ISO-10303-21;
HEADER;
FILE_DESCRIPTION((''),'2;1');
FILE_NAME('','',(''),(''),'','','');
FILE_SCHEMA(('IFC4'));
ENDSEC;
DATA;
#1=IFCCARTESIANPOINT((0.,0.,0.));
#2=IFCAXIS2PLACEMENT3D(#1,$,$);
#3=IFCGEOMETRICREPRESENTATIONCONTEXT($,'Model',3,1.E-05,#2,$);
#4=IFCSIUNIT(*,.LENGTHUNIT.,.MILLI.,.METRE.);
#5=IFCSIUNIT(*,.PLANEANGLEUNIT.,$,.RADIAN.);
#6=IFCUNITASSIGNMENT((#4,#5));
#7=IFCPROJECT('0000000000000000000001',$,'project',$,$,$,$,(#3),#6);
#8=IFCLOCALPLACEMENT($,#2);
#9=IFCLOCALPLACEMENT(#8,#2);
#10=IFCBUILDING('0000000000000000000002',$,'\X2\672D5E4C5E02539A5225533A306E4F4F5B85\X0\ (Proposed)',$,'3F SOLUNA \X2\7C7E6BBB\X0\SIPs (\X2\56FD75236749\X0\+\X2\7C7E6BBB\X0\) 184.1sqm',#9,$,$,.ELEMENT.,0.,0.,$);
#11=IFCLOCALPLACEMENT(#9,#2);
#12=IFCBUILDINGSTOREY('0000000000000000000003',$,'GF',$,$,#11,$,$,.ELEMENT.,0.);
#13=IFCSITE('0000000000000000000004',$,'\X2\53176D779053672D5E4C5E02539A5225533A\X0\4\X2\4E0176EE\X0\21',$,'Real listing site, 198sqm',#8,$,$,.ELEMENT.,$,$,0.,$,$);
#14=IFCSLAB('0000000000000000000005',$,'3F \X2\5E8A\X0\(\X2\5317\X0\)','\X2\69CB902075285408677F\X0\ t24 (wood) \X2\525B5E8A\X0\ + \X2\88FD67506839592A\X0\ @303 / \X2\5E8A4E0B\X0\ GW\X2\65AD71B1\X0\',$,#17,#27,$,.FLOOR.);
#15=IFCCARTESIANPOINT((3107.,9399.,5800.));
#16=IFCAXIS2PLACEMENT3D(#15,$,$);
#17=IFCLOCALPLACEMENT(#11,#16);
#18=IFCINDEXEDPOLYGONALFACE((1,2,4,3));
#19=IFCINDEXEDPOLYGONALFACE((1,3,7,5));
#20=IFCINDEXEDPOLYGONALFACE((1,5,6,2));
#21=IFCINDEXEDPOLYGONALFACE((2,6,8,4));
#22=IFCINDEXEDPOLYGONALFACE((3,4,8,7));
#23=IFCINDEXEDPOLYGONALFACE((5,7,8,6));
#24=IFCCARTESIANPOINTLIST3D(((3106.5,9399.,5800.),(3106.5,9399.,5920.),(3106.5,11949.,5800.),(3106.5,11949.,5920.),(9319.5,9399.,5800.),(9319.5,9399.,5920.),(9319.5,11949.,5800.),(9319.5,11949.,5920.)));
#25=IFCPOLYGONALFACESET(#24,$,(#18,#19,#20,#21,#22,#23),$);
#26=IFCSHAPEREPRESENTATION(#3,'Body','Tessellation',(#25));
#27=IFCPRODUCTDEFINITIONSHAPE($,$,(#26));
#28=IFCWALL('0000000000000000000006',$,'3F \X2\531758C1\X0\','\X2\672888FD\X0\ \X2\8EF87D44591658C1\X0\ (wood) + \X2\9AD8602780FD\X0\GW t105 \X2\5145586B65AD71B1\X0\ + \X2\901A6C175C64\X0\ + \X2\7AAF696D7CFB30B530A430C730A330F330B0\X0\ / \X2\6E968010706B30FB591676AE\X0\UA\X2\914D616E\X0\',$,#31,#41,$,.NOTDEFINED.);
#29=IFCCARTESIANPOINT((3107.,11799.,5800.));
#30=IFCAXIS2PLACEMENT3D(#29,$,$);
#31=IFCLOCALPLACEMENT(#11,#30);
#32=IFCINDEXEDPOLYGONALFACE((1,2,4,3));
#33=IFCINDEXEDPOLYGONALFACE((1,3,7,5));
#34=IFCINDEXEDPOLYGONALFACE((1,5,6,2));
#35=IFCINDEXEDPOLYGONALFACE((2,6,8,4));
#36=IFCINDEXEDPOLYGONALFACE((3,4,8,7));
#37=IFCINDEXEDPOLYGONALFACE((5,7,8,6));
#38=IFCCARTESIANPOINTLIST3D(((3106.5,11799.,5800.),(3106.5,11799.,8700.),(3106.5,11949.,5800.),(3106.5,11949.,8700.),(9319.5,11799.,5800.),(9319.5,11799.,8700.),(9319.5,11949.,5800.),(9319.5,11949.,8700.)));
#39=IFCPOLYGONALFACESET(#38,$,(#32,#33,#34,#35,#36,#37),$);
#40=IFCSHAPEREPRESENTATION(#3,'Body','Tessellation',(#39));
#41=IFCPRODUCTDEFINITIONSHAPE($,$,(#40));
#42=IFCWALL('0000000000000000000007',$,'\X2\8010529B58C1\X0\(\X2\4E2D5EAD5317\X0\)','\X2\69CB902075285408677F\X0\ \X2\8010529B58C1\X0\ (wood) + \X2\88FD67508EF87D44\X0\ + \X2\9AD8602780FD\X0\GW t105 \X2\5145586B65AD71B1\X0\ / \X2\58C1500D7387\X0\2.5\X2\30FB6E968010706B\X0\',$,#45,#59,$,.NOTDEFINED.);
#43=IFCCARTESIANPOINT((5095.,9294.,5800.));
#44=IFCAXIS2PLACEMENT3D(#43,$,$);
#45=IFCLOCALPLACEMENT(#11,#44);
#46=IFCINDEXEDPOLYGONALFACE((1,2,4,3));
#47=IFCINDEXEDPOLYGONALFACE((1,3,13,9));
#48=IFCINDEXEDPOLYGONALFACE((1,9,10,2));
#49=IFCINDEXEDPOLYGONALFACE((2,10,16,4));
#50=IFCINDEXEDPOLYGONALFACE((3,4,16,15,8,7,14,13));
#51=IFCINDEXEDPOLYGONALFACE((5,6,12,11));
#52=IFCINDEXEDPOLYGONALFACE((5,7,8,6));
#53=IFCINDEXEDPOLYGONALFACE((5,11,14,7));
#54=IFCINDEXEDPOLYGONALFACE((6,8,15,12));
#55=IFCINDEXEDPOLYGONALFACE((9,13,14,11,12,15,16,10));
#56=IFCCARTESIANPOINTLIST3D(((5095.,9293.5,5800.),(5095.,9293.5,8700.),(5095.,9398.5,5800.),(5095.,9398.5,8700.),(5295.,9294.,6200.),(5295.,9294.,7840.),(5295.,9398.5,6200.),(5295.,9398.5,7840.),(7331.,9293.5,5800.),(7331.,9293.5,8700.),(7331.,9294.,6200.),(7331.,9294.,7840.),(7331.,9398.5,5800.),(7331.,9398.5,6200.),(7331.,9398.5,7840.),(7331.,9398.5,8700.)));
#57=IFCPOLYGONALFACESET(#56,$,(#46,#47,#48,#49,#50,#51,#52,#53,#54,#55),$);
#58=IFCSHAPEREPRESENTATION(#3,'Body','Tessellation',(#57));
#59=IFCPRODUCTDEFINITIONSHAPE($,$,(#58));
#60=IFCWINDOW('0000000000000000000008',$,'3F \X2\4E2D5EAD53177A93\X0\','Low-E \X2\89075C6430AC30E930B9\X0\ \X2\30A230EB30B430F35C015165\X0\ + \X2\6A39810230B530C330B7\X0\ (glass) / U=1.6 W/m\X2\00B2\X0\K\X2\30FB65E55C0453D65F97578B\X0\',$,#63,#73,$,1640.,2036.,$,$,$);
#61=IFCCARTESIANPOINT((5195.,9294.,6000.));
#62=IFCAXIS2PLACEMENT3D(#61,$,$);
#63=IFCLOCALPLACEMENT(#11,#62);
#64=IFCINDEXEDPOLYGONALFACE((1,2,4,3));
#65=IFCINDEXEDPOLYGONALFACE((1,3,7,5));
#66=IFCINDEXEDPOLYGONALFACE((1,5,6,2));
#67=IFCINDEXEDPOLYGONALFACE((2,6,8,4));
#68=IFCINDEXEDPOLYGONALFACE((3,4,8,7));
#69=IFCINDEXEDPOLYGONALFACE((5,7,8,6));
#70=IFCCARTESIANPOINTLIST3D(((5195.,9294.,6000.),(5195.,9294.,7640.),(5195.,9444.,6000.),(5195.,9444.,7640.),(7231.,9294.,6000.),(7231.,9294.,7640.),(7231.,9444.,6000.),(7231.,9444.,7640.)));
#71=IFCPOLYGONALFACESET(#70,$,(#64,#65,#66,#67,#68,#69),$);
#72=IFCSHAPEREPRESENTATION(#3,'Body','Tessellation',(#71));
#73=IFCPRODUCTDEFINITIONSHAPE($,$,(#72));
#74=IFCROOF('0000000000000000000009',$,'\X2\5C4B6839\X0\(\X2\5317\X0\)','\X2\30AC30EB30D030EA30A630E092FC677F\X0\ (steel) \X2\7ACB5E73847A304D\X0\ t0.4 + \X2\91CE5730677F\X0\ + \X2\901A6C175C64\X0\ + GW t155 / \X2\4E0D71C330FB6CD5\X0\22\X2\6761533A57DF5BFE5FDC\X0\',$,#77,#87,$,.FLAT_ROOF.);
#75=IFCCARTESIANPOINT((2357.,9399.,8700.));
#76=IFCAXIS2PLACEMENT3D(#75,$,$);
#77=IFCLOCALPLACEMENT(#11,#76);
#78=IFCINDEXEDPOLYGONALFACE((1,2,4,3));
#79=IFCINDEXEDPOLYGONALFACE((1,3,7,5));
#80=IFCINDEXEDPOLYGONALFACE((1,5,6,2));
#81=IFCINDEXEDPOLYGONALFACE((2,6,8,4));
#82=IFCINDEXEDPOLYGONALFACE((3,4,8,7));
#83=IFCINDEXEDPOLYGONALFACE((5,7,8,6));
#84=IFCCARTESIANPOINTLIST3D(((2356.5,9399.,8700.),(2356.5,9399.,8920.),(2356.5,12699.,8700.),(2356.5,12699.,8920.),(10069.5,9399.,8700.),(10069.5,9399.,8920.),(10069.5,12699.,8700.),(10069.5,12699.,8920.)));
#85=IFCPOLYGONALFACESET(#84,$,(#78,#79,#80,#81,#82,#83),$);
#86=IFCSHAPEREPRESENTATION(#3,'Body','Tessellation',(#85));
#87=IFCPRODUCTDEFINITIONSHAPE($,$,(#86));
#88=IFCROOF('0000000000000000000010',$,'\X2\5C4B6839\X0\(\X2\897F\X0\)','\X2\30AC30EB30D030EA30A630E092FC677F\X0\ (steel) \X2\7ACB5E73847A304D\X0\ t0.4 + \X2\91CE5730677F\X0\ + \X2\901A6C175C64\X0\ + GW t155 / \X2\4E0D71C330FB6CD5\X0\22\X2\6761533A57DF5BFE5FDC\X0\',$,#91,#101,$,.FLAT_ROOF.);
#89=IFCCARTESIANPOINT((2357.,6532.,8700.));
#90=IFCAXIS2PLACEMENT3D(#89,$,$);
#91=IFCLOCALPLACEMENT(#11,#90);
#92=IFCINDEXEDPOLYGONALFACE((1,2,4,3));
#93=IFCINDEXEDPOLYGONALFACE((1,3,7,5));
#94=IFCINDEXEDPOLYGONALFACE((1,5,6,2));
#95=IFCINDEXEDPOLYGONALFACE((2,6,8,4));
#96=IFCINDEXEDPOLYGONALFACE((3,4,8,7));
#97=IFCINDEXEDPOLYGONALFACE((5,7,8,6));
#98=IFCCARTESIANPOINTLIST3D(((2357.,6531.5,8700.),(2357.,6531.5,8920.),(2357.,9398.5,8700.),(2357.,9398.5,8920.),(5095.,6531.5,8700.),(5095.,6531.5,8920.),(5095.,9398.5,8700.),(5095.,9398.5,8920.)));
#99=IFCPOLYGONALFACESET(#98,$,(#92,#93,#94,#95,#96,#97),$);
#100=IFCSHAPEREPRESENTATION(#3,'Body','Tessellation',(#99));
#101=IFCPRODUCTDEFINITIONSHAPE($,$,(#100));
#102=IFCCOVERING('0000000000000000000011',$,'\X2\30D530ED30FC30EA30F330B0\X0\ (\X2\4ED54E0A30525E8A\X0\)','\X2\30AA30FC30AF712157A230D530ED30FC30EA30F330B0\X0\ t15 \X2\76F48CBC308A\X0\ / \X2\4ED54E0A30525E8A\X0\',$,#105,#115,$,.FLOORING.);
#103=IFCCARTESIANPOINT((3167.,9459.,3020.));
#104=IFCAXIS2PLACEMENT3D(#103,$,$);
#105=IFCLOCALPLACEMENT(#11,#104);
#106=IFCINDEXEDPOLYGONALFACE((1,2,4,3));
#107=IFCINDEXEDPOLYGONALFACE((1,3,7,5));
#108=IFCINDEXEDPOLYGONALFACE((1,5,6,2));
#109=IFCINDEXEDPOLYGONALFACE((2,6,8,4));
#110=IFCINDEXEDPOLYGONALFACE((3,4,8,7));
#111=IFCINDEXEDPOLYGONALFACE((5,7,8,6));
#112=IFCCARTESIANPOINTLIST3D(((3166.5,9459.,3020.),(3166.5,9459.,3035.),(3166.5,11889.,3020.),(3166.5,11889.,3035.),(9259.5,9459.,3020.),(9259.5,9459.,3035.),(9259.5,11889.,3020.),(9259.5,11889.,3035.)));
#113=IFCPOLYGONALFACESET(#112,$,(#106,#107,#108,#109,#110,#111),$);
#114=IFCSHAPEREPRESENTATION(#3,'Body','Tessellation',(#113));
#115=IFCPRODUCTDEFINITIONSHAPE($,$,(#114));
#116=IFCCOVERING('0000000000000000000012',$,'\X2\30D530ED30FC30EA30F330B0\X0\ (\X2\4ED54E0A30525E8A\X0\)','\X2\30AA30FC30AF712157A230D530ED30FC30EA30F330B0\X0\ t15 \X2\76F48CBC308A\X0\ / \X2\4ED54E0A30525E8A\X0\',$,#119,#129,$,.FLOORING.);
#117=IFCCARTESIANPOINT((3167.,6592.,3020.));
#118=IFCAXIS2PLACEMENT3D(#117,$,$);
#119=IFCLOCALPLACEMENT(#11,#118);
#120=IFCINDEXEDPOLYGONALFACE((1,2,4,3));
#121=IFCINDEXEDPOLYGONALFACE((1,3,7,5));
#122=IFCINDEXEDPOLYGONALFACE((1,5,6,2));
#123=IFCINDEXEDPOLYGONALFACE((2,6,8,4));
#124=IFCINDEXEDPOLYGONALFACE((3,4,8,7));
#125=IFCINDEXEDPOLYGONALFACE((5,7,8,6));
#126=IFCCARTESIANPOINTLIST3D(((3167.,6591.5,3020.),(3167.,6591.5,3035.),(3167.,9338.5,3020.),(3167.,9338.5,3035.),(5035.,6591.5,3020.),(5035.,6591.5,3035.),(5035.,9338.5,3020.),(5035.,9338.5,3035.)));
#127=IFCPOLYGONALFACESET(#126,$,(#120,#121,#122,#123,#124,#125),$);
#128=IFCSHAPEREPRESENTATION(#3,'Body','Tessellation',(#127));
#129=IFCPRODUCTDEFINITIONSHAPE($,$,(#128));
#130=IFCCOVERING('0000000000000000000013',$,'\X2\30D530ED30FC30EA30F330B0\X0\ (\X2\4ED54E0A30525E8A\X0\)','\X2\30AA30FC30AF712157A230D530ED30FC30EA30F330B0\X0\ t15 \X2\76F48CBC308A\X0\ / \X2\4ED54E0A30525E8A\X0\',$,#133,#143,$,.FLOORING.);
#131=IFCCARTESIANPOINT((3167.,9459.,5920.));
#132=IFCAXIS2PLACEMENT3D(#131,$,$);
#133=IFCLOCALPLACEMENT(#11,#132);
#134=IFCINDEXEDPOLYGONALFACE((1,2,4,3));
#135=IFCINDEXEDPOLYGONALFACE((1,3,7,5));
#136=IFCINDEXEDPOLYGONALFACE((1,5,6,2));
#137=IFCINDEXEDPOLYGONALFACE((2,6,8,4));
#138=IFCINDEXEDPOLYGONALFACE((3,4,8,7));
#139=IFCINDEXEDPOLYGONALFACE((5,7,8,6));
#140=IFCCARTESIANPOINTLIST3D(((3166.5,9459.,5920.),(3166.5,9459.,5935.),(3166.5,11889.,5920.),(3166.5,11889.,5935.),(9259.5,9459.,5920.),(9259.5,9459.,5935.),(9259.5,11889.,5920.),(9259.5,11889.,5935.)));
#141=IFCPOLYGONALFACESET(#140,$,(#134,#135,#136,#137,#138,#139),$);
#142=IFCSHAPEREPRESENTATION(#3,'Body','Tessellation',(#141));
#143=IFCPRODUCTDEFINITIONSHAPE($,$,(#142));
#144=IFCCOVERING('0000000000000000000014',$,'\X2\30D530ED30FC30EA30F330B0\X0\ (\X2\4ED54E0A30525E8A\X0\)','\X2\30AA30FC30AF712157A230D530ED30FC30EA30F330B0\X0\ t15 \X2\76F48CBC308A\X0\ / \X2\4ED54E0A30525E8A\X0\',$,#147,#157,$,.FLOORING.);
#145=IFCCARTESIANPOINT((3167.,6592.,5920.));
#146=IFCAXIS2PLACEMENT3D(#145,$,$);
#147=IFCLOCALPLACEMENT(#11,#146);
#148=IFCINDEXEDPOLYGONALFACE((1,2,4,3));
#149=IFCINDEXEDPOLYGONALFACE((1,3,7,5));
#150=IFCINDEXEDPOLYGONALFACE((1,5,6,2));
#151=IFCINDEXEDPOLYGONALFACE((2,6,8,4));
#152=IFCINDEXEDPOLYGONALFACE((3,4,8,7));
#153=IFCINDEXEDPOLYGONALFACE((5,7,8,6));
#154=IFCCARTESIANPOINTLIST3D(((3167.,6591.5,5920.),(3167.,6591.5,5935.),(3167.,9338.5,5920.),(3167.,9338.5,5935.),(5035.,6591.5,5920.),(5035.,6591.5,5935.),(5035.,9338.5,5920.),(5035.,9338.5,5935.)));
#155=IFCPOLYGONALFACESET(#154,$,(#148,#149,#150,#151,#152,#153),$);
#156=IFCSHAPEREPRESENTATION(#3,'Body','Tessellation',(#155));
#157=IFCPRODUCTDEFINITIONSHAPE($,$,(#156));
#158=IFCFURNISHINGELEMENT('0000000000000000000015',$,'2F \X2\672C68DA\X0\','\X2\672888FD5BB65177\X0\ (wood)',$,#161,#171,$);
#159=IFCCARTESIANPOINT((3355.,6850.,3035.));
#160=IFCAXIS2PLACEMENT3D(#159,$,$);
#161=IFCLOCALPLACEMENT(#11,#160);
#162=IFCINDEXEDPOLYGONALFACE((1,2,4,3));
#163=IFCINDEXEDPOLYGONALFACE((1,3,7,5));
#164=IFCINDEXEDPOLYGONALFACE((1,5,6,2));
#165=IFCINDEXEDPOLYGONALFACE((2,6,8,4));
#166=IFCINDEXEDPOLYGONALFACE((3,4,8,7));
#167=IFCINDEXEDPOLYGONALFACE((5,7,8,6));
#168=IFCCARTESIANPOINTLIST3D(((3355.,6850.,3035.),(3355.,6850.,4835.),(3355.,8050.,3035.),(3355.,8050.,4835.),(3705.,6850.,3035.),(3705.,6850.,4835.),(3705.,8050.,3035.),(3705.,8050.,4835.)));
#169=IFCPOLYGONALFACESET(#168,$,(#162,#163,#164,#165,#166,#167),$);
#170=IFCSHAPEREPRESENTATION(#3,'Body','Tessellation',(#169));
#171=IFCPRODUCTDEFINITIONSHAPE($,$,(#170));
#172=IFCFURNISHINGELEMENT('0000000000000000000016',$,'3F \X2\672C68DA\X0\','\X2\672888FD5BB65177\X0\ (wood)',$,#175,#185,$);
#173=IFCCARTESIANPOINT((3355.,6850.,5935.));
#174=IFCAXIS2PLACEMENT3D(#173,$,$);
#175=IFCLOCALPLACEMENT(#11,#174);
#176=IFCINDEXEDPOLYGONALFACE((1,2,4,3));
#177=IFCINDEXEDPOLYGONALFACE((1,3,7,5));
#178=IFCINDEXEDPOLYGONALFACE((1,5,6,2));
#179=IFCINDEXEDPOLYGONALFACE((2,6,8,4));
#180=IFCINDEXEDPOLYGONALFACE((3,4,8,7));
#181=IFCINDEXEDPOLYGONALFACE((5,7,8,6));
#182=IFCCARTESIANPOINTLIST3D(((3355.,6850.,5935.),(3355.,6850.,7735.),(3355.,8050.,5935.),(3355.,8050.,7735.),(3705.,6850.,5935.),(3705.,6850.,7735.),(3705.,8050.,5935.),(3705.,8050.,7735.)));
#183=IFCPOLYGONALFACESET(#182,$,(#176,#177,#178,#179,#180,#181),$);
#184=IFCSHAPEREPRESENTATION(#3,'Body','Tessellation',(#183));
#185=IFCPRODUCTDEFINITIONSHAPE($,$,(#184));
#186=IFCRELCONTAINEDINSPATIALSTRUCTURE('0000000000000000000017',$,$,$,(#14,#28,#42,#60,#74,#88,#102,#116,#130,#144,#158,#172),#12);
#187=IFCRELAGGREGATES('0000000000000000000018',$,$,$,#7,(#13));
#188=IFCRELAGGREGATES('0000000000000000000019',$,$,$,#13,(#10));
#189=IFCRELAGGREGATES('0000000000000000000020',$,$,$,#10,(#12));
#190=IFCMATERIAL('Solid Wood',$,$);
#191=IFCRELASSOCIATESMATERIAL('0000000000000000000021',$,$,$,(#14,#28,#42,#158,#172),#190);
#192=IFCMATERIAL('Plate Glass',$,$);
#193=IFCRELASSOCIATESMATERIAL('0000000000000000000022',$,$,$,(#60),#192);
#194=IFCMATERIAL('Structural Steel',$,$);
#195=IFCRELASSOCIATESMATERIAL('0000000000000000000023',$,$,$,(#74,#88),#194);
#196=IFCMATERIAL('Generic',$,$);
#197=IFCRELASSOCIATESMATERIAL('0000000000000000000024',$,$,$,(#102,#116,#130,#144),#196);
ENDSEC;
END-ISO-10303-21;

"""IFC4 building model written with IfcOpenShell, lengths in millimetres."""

from ifc_helpers import new_model, si_unit, frame, frame_2d, origin, place, context, project, spatial, rectangle, extrude, material, element, fill, save


model = new_model("IFC4")

# Units and contexts
model_context = context("Model", 3, precision=1e-05, world=origin())
ifc_project = project(units=[si_unit("LENGTHUNIT", "METRE", prefix="MILLI"), si_unit("PLANEANGLEUNIT", "RADIAN")], contexts=[model_context])

# Site, building, storey
site_placement = place(None, origin())
site = spatial("IfcSite", under=ifc_project, at=site_placement, Name="北海道札幌市厚別区4丁目21", ObjectType="Real listing site, 198sqm", CompositionType="ELEMENT", RefElevation=0.0)
building_placement = place(site_placement, origin())
building = spatial("IfcBuilding", under=site, at=building_placement, Name="札幌市厚別区の住宅 (Proposed)", ObjectType="3F SOLUNA 籾殻SIPs (国産杉+籾殻) 184.1sqm", CompositionType="ELEMENT", ElevationOfRefHeight=0.0, ElevationOfTerrain=0.0)
storey_placement = place(building_placement, origin())
storey = spatial("IfcBuildingStorey", under=building, at=storey_placement, Name="GF", CompositionType="ELEMENT", Elevation=0.0)

# Slab
ifc_material_1 = material(Name="Solid Wood")
slab_placement = place(storey_placement, frame((3107.0, 9399.0, 5800.0)))
element("IfcSlab", 1, at=slab_placement, inside=storey, material=ifc_material_1, Name="3F 床(北)", Description="構造用合板 t24 (wood) 剛床 + 製材根太 @303 / 床下 GW断熱", PredefinedType="FLOOR", context=model_context, shape_type="SweptSolid", body=[
    extrude(rectangle(XDim=6213.0, YDim=2550.0, at=frame_2d((3106.0, 1275.0))), frame((3107.0, 9399.0, 5800.0)), (0.0, 0.0, 1.0), 120.0),
])

# Wall
wall_1_placement = place(storey_placement, frame((3107.0, 11799.0, 5800.0)))
element("IfcWall", 2, at=wall_1_placement, inside=storey, material=ifc_material_1, Name="3F 北壁", Description="木製 軸組外壁 (wood) + 高性能GW t105 充填断熱 + 通気層 + 窯業系サイディング / 準耐火・外皮UA配慮", PredefinedType="NOTDEFINED", context=model_context, shape_type="SweptSolid", body=[
    extrude(rectangle(XDim=6213.0, YDim=150.0, at=frame_2d((3106.0, 75.0))), frame((3107.0, 11799.0, 5800.0)), (0.0, 0.0, 1.0), 2900.0),
])

# Wall, opening, window
wall_2_placement = place(storey_placement, frame((5095.0, 9294.0, 5800.0)))
wall_2 = element("IfcWall", 3, at=wall_2_placement, inside=storey, material=ifc_material_1, Name="耐力壁(中庭北)", Description="構造用合板 耐力壁 (wood) + 製材軸組 + 高性能GW t105 充填断熱 / 壁倍率2.5・準耐火", PredefinedType="NOTDEFINED", context=model_context, shape_type="SweptSolid", body=[
    extrude(rectangle(XDim=2236.0, YDim=105.0, at=frame_2d((1118.0, 52.0))), frame((5095.0, 9294.0, 5800.0)), (0.0, 0.0, 1.0), 2900.0),
])
opening_placement = place(storey_placement, frame((5195.0, 9294.0, 6000.0)))
opening = element("IfcOpeningElement", 4, at=opening_placement, cuts=wall_2, PredefinedType="NOTDEFINED", context=model_context, shape_type="SweptSolid", body=[
    extrude(rectangle(XDim=2036.0, YDim=150.0, at=frame_2d((1018.0, 75.0))), frame((5195.0, 9294.0, 6000.0)), (0.0, 0.0, 1.0), 1640.0),
])
ifc_material_2 = material(Name="Plate Glass")
window_1_placement = place(storey_placement, frame((5195.0, 9294.0, 6000.0)))
window_1 = element("IfcWindow", 5, at=window_1_placement, inside=storey, material=ifc_material_2, Name="3F 中庭北窓", Description="Low-E 複層ガラス アルゴン封入 + 樹脂サッシ (glass) / U=1.6 W/m²K・日射取得型", OverallHeight=1640.0, OverallWidth=2036.0, context=model_context, shape_type="SweptSolid", body=[
    extrude(rectangle(XDim=2036.0, YDim=150.0, at=frame_2d((1018.0, 75.0))), frame((5195.0, 9294.0, 6000.0)), (0.0, 0.0, 1.0), 1640.0),
])
fill(opening, window_1)

# Shared definitions
ifc_material_3 = material(Name="Generic")

# Roofs
ifc_material_4 = material(Name="Structural Steel")
roof_1_placement = place(storey_placement, frame((2357.0, 9399.0, 8700.0)))
element("IfcRoof", 6, at=roof_1_placement, inside=storey, material=ifc_material_4, Name="屋根(北)", Description="ガルバリウム鋼板 (steel) 立平葺き t0.4 + 野地板 + 通気層 + GW t155 / 不燃・法22条区域対応", PredefinedType="FLAT_ROOF", context=model_context, shape_type="SweptSolid", body=[
    extrude(rectangle(XDim=7713.0, YDim=3300.0, at=frame_2d((3856.0, 1650.0))), frame((2357.0, 9399.0, 8700.0)), (0.0, 0.0, 1.0), 220.0),
])
roof_2_placement = place(storey_placement, frame((2357.0, 6532.0, 8700.0)))
element("IfcRoof", 7, at=roof_2_placement, inside=storey, material=ifc_material_4, Name="屋根(西)", Description="ガルバリウム鋼板 (steel) 立平葺き t0.4 + 野地板 + 通気層 + GW t155 / 不燃・法22条区域対応", PredefinedType="FLAT_ROOF", context=model_context, shape_type="SweptSolid", body=[
    extrude(rectangle(XDim=2738.0, YDim=2867.0, at=frame_2d((1369.0, 1433.0))), frame((2357.0, 6532.0, 8700.0)), (0.0, 0.0, 1.0), 220.0),
])

# Coverings
covering_1_placement = place(storey_placement, frame((3167.0, 9459.0, 3020.0)))
element("IfcCovering", 8, at=covering_1_placement, inside=storey, material=ifc_material_3, Name="フローリング (仕上げ床)", Description="オーク無垢フローリング t15 直貼り / 仕上げ床", PredefinedType="FLOORING", context=model_context, shape_type="SweptSolid", body=[
    extrude(rectangle(XDim=6093.0, YDim=2430.0, at=frame_2d((3046.0, 1215.0))), frame((3167.0, 9459.0, 3020.0)), (0.0, 0.0, 1.0), 15.0),
])
covering_2_placement = place(storey_placement, frame((3167.0, 6592.0, 3020.0)))
element("IfcCovering", 9, at=covering_2_placement, inside=storey, material=ifc_material_3, Name="フローリング (仕上げ床)", Description="オーク無垢フローリング t15 直貼り / 仕上げ床", PredefinedType="FLOORING", context=model_context, shape_type="SweptSolid", body=[
    extrude(rectangle(XDim=1868.0, YDim=2747.0, at=frame_2d((934.0, 1373.0))), frame((3167.0, 6592.0, 3020.0)), (0.0, 0.0, 1.0), 15.0),
])
covering_3_placement = place(storey_placement, frame((3167.0, 9459.0, 5920.0)))
element("IfcCovering", 10, at=covering_3_placement, inside=storey, material=ifc_material_3, Name="フローリング (仕上げ床)", Description="オーク無垢フローリング t15 直貼り / 仕上げ床", PredefinedType="FLOORING", context=model_context, shape_type="SweptSolid", body=[
    extrude(rectangle(XDim=6093.0, YDim=2430.0, at=frame_2d((3046.0, 1215.0))), frame((3167.0, 9459.0, 5920.0)), (0.0, 0.0, 1.0), 15.0),
])
covering_4_placement = place(storey_placement, frame((3167.0, 6592.0, 5920.0)))
element("IfcCovering", 11, at=covering_4_placement, inside=storey, material=ifc_material_3, Name="フローリング (仕上げ床)", Description="オーク無垢フローリング t15 直貼り / 仕上げ床", PredefinedType="FLOORING", context=model_context, shape_type="SweptSolid", body=[
    extrude(rectangle(XDim=1868.0, YDim=2747.0, at=frame_2d((934.0, 1373.0))), frame((3167.0, 6592.0, 5920.0)), (0.0, 0.0, 1.0), 15.0),
])

# Furnishing elements
furnishing_1_placement = place(storey_placement, frame((3355.0, 6850.0, 3035.0)))
element("IfcFurnishingElement", 12, at=furnishing_1_placement, inside=storey, material=ifc_material_1, Name="2F 本棚", Description="木製家具 (wood)", context=model_context, shape_type="SweptSolid", body=[
    extrude(rectangle(XDim=350.0, YDim=1200.0, at=frame_2d((175.0, 600.0))), frame((3355.0, 6850.0, 3035.0)), (0.0, 0.0, 1.0), 1800.0),
])
furnishing_2_placement = place(storey_placement, frame((3355.0, 6850.0, 5935.0)))
element("IfcFurnishingElement", 13, at=furnishing_2_placement, inside=storey, material=ifc_material_1, Name="3F 本棚", Description="木製家具 (wood)", context=model_context, shape_type="SweptSolid", body=[
    extrude(rectangle(XDim=350.0, YDim=1200.0, at=frame_2d((175.0, 600.0))), frame((3355.0, 6850.0, 5935.0)), (0.0, 0.0, 1.0), 1800.0),
])

save(model, "model.ifc")
